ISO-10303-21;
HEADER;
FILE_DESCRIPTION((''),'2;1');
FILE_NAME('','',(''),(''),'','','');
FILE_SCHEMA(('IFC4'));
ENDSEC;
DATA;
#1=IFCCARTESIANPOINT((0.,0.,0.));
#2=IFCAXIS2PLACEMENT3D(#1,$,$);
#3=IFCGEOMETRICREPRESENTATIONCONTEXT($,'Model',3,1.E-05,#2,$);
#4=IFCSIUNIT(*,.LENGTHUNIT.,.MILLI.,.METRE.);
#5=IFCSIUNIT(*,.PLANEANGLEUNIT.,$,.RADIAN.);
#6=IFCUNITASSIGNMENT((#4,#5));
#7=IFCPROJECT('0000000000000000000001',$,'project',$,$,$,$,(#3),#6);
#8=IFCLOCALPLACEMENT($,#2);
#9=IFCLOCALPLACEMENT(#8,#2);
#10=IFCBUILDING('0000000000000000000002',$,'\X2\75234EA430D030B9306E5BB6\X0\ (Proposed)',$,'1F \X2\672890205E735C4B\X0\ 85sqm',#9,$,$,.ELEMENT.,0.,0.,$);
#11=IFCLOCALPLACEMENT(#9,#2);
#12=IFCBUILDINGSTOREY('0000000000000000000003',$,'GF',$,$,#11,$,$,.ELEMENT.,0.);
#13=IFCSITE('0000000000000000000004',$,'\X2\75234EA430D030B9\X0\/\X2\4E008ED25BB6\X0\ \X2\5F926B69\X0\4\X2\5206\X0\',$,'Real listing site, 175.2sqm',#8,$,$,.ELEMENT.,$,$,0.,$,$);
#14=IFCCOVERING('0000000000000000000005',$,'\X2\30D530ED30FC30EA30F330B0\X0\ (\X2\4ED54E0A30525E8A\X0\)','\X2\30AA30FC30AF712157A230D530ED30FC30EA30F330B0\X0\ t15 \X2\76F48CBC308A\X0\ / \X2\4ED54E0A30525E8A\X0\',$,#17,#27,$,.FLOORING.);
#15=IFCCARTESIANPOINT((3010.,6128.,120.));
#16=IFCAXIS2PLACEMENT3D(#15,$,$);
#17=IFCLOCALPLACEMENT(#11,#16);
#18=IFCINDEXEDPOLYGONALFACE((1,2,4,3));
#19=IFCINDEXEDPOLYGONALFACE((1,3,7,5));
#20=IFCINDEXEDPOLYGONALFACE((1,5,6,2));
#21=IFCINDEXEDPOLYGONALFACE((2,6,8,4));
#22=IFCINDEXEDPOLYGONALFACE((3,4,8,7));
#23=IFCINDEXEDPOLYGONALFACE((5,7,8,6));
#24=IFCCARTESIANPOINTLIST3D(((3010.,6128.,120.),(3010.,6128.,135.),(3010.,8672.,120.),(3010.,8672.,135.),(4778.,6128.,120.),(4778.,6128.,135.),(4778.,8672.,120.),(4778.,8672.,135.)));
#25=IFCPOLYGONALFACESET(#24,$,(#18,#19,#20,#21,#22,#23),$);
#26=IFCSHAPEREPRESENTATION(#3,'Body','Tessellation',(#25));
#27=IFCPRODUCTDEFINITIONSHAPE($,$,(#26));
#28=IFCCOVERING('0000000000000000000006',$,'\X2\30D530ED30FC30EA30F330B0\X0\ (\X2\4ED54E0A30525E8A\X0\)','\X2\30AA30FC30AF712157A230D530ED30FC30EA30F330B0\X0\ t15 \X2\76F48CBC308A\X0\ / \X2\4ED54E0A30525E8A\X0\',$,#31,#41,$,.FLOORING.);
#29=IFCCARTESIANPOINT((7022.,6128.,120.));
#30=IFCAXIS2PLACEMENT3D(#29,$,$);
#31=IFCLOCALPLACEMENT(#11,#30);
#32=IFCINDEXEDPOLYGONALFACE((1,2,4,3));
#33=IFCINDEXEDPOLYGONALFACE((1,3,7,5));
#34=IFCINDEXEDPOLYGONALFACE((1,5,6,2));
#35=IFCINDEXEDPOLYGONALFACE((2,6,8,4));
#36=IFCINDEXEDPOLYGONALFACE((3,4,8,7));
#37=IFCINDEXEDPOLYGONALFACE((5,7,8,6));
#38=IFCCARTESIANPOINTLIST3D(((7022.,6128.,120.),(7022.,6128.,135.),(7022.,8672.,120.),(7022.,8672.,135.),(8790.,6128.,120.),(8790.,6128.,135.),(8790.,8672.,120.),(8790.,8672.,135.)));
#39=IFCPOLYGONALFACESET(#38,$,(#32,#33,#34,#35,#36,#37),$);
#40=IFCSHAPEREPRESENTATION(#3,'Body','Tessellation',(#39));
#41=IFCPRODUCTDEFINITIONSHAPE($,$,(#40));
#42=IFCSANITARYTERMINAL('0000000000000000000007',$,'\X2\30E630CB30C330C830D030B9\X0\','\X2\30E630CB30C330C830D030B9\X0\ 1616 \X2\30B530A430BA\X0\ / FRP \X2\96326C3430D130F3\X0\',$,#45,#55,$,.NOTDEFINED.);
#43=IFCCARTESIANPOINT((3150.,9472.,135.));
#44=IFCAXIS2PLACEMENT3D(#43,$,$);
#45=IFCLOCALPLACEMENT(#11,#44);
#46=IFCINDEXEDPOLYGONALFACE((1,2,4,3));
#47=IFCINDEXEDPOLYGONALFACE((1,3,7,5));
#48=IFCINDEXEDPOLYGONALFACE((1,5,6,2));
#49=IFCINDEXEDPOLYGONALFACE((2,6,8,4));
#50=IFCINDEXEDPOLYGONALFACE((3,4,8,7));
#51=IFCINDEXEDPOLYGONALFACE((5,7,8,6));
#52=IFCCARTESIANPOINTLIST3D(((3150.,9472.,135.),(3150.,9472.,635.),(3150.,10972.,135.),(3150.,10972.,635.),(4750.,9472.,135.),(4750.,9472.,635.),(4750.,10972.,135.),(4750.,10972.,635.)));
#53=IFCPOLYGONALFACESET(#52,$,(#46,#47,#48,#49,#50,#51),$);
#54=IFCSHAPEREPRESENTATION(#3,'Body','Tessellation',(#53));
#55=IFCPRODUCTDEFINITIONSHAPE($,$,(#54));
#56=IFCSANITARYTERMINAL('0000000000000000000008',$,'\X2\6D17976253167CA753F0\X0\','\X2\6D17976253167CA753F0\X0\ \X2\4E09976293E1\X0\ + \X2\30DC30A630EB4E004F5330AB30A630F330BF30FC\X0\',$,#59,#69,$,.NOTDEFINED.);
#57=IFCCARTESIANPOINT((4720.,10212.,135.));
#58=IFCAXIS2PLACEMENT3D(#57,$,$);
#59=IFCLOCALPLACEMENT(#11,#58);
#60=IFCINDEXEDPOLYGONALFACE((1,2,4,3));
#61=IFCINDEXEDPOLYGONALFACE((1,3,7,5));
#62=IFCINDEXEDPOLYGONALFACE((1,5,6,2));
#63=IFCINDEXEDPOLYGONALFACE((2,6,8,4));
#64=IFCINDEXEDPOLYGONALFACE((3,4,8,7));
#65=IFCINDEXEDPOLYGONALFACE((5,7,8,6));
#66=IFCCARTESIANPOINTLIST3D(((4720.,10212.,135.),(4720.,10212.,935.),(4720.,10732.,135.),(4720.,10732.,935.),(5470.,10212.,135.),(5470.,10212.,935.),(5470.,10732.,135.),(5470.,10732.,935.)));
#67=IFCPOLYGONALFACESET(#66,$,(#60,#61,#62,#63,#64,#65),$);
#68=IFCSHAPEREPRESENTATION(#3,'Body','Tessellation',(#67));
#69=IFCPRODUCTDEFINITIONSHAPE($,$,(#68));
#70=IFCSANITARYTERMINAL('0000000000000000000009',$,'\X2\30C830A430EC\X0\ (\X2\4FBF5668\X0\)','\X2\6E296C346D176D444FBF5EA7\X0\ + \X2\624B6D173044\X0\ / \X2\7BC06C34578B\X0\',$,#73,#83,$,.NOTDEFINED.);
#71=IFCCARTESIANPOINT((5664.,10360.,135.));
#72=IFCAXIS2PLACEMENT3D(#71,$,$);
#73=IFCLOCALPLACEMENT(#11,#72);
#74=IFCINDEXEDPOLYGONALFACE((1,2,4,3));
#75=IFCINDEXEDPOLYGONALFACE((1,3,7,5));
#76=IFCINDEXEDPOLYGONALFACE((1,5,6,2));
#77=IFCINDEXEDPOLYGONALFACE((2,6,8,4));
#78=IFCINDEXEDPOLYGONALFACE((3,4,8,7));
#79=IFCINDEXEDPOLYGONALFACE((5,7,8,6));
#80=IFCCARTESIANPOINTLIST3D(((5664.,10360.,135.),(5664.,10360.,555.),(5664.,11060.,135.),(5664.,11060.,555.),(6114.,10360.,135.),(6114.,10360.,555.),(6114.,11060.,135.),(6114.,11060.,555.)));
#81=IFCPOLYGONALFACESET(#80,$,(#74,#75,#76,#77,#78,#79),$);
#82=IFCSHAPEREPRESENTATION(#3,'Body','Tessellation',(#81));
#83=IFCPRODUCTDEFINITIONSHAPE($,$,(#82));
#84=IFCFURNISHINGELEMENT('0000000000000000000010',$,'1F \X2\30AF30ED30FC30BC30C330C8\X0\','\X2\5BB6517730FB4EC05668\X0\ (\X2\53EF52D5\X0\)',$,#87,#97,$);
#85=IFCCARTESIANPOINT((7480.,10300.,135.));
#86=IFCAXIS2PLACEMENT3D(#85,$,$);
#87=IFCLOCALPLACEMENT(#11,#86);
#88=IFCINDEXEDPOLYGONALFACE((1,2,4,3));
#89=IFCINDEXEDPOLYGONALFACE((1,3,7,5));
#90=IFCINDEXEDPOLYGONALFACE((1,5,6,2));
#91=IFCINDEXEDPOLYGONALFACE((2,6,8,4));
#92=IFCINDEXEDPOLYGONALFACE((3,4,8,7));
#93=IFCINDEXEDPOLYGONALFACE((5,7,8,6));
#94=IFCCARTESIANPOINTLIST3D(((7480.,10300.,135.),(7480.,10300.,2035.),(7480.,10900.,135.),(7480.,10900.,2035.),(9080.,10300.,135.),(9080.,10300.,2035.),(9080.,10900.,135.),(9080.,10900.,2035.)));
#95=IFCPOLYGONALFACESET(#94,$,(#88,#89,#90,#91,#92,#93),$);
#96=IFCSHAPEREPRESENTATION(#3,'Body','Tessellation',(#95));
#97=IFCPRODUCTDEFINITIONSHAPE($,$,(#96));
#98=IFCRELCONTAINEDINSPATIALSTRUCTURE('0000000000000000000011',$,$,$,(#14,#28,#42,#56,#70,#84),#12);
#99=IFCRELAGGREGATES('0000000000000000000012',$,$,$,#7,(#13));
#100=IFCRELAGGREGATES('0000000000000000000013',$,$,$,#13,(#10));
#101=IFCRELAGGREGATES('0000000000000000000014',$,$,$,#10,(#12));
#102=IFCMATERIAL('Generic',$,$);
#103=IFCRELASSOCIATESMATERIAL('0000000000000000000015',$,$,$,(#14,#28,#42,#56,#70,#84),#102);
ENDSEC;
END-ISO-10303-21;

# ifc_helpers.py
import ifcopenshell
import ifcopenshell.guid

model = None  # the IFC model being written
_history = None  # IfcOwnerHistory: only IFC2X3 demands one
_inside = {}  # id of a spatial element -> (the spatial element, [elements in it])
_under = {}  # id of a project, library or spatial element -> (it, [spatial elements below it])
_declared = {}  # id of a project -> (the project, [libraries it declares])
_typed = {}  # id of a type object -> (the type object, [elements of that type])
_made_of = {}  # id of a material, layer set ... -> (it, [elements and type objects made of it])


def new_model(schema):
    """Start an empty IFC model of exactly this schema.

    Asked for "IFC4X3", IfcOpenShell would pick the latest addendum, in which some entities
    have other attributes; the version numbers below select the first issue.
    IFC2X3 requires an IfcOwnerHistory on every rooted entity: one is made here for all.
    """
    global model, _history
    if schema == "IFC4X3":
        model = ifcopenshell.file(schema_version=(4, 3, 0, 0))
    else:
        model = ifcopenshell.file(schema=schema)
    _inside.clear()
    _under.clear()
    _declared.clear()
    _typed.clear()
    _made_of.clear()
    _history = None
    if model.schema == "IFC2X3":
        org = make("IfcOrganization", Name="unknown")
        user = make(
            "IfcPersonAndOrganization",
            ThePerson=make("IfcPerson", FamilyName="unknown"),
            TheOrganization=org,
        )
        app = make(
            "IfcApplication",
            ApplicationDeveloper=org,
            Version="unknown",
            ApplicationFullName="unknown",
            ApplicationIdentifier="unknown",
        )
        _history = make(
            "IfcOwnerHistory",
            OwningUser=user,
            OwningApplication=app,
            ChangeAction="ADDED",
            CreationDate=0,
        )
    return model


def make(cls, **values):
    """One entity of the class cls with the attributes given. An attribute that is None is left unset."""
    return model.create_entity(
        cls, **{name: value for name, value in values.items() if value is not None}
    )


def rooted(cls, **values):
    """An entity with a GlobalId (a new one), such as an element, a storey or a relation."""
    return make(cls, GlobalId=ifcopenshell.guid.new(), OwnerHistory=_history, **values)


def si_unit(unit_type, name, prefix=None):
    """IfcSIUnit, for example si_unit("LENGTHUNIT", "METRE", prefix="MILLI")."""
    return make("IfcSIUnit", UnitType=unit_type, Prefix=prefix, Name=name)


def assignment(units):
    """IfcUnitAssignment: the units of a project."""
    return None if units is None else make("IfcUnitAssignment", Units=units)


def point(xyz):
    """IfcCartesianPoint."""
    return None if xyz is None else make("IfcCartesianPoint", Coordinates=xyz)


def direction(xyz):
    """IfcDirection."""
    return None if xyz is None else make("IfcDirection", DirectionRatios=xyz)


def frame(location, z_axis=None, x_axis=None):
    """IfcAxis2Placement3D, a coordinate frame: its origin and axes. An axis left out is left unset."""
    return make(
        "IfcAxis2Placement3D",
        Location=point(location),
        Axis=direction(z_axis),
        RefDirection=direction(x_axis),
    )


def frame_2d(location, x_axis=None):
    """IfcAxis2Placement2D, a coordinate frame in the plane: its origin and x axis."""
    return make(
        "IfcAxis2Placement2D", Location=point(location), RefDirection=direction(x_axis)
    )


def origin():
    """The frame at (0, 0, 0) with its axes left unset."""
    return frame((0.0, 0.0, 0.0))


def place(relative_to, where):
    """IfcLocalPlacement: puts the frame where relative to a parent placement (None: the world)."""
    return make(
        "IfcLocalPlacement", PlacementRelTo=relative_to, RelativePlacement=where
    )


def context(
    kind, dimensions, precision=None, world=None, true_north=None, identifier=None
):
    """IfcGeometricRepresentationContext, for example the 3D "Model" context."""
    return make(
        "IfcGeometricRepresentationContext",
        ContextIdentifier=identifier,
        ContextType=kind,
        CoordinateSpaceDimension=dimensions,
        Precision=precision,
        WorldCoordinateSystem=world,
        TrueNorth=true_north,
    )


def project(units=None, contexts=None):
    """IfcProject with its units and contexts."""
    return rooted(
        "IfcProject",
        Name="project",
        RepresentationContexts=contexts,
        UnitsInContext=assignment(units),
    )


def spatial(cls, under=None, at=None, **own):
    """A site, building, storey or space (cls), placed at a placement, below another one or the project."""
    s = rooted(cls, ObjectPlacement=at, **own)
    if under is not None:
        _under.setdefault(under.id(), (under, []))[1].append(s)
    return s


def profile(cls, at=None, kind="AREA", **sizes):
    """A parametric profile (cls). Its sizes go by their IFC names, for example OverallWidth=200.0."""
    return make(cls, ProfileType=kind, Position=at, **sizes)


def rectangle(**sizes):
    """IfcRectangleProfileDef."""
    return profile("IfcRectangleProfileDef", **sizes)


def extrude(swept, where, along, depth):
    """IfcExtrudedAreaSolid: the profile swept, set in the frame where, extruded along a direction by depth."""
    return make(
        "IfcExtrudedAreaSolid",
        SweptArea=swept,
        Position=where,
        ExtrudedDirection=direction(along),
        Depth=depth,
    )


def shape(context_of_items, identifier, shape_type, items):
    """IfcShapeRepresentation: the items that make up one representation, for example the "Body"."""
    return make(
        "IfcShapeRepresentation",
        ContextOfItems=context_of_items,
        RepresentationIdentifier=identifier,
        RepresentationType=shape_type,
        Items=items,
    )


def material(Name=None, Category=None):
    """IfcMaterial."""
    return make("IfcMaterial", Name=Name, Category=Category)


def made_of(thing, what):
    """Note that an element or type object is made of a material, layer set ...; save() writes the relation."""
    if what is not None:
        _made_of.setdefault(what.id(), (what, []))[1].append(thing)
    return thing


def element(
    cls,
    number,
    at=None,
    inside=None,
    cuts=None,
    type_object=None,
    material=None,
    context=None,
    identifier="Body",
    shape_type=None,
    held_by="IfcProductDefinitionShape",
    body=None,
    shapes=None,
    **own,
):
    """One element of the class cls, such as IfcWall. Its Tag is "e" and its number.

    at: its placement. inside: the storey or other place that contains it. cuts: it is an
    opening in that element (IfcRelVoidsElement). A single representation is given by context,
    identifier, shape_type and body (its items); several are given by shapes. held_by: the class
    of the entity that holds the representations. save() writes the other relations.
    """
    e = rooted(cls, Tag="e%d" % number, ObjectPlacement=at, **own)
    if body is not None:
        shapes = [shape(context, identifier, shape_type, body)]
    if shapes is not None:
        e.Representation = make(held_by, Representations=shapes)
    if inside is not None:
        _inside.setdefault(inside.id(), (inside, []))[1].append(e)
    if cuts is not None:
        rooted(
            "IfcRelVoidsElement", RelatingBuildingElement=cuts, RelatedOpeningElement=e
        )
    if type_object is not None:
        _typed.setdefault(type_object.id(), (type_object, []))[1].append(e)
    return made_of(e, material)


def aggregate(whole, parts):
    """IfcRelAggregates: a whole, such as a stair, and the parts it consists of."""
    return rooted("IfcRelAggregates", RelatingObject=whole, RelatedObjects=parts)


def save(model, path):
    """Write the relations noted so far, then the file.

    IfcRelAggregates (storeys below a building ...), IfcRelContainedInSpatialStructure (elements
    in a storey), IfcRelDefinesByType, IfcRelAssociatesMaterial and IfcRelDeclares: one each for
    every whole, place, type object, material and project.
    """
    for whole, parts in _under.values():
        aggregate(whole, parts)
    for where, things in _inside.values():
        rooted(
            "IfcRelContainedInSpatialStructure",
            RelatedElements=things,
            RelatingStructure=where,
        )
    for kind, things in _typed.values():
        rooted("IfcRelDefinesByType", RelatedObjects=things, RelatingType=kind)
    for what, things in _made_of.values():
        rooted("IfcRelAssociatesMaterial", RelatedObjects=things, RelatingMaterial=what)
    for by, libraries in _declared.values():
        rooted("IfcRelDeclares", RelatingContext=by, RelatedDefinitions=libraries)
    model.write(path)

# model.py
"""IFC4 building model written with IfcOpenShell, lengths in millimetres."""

from ifc_helpers import new_model, si_unit, frame, frame_2d, origin, place, context, project, spatial, rectangle, extrude, material, element, save


model = new_model("IFC4")

# Units and contexts
model_context = context("Model", 3, precision=1e-05, world=origin())
ifc_project = project(units=[si_unit("LENGTHUNIT", "METRE", prefix="MILLI"), si_unit("PLANEANGLEUNIT", "RADIAN")], contexts=[model_context])

# Site, building, storey
site_placement = place(None, origin())
site = spatial("IfcSite", under=ifc_project, at=site_placement, Name="産交バス/一軒家 徒歩4分", ObjectType="Real listing site, 175.2sqm", CompositionType="ELEMENT", RefElevation=0.0)
building_placement = place(site_placement, origin())
building = spatial("IfcBuilding", under=site, at=building_placement, Name="産交バスの家 (Proposed)", ObjectType="1F 木造平屋 85sqm", CompositionType="ELEMENT", ElevationOfRefHeight=0.0, ElevationOfTerrain=0.0)
storey_placement = place(building_placement, origin())
storey = spatial("IfcBuildingStorey", under=building, at=storey_placement, Name="GF", CompositionType="ELEMENT", Elevation=0.0)

# Coverings
ifc_material_1 = material(Name="Generic")
covering_1_placement = place(storey_placement, frame((3010.0, 6128.0, 120.0)))
element("IfcCovering", 1, at=covering_1_placement, inside=storey, material=ifc_material_1, Name="フローリング (仕上げ床)", Description="オーク無垢フローリング t15 直貼り / 仕上げ床", PredefinedType="FLOORING", context=model_context, shape_type="SweptSolid", body=[
    extrude(rectangle(XDim=1768.0, YDim=2544.0, at=frame_2d((884.0, 1272.0))), frame((3010.0, 6128.0, 120.0)), (0.0, 0.0, 1.0), 15.0),
])
covering_2_placement = place(storey_placement, frame((7022.0, 6128.0, 120.0)))
element("IfcCovering", 2, at=covering_2_placement, inside=storey, material=ifc_material_1, Name="フローリング (仕上げ床)", Description="オーク無垢フローリング t15 直貼り / 仕上げ床", PredefinedType="FLOORING", context=model_context, shape_type="SweptSolid", body=[
    extrude(rectangle(XDim=1768.0, YDim=2544.0, at=frame_2d((884.0, 1272.0))), frame((7022.0, 6128.0, 120.0)), (0.0, 0.0, 1.0), 15.0),
])

# Sanitary terminals
sanitary_terminal_1_placement = place(storey_placement, frame((3150.0, 9472.0, 135.0)))
element("IfcSanitaryTerminal", 3, at=sanitary_terminal_1_placement, inside=storey, material=ifc_material_1, Name="ユニットバス", Description="ユニットバス 1616 サイズ / FRP 防水パン", PredefinedType="NOTDEFINED", context=model_context, shape_type="SweptSolid", body=[
    extrude(rectangle(XDim=1600.0, YDim=1500.0, at=frame_2d((800.0, 750.0))), frame((3150.0, 9472.0, 135.0)), (0.0, 0.0, 1.0), 500.0),
])
sanitary_terminal_2_placement = place(storey_placement, frame((4720.0, 10212.0, 135.0)))
element("IfcSanitaryTerminal", 4, at=sanitary_terminal_2_placement, inside=storey, material=ifc_material_1, Name="洗面化粧台", Description="洗面化粧台 三面鏡 + ボウル一体カウンター", PredefinedType="NOTDEFINED", context=model_context, shape_type="SweptSolid", body=[
    extrude(rectangle(XDim=750.0, YDim=520.0, at=frame_2d((375.0, 260.0))), frame((4720.0, 10212.0, 135.0)), (0.0, 0.0, 1.0), 800.0),
])
sanitary_terminal_3_placement = place(storey_placement, frame((5664.0, 10360.0, 135.0)))
element("IfcSanitaryTerminal", 5, at=sanitary_terminal_3_placement, inside=storey, material=ifc_material_1, Name="トイレ (便器)", Description="温水洗浄便座 + 手洗い / 節水型", PredefinedType="NOTDEFINED", context=model_context, shape_type="SweptSolid", body=[
    extrude(rectangle(XDim=450.0, YDim=700.0, at=frame_2d((225.0, 350.0))), frame((5664.0, 10360.0, 135.0)), (0.0, 0.0, 1.0), 420.0),
])

# Furnishing element
furnishing_placement = place(storey_placement, frame((7480.0, 10300.0, 135.0)))
element("IfcFurnishingElement", 6, at=furnishing_placement, inside=storey, material=ifc_material_1, Name="1F クローゼット", Description="家具・什器 (可動)", context=model_context, shape_type="SweptSolid", body=[
    extrude(rectangle(XDim=1600.0, YDim=600.0, at=frame_2d((800.0, 300.0))), frame((7480.0, 10300.0, 135.0)), (0.0, 0.0, 1.0), 1900.0),
])

save(model, "model.ifc")
